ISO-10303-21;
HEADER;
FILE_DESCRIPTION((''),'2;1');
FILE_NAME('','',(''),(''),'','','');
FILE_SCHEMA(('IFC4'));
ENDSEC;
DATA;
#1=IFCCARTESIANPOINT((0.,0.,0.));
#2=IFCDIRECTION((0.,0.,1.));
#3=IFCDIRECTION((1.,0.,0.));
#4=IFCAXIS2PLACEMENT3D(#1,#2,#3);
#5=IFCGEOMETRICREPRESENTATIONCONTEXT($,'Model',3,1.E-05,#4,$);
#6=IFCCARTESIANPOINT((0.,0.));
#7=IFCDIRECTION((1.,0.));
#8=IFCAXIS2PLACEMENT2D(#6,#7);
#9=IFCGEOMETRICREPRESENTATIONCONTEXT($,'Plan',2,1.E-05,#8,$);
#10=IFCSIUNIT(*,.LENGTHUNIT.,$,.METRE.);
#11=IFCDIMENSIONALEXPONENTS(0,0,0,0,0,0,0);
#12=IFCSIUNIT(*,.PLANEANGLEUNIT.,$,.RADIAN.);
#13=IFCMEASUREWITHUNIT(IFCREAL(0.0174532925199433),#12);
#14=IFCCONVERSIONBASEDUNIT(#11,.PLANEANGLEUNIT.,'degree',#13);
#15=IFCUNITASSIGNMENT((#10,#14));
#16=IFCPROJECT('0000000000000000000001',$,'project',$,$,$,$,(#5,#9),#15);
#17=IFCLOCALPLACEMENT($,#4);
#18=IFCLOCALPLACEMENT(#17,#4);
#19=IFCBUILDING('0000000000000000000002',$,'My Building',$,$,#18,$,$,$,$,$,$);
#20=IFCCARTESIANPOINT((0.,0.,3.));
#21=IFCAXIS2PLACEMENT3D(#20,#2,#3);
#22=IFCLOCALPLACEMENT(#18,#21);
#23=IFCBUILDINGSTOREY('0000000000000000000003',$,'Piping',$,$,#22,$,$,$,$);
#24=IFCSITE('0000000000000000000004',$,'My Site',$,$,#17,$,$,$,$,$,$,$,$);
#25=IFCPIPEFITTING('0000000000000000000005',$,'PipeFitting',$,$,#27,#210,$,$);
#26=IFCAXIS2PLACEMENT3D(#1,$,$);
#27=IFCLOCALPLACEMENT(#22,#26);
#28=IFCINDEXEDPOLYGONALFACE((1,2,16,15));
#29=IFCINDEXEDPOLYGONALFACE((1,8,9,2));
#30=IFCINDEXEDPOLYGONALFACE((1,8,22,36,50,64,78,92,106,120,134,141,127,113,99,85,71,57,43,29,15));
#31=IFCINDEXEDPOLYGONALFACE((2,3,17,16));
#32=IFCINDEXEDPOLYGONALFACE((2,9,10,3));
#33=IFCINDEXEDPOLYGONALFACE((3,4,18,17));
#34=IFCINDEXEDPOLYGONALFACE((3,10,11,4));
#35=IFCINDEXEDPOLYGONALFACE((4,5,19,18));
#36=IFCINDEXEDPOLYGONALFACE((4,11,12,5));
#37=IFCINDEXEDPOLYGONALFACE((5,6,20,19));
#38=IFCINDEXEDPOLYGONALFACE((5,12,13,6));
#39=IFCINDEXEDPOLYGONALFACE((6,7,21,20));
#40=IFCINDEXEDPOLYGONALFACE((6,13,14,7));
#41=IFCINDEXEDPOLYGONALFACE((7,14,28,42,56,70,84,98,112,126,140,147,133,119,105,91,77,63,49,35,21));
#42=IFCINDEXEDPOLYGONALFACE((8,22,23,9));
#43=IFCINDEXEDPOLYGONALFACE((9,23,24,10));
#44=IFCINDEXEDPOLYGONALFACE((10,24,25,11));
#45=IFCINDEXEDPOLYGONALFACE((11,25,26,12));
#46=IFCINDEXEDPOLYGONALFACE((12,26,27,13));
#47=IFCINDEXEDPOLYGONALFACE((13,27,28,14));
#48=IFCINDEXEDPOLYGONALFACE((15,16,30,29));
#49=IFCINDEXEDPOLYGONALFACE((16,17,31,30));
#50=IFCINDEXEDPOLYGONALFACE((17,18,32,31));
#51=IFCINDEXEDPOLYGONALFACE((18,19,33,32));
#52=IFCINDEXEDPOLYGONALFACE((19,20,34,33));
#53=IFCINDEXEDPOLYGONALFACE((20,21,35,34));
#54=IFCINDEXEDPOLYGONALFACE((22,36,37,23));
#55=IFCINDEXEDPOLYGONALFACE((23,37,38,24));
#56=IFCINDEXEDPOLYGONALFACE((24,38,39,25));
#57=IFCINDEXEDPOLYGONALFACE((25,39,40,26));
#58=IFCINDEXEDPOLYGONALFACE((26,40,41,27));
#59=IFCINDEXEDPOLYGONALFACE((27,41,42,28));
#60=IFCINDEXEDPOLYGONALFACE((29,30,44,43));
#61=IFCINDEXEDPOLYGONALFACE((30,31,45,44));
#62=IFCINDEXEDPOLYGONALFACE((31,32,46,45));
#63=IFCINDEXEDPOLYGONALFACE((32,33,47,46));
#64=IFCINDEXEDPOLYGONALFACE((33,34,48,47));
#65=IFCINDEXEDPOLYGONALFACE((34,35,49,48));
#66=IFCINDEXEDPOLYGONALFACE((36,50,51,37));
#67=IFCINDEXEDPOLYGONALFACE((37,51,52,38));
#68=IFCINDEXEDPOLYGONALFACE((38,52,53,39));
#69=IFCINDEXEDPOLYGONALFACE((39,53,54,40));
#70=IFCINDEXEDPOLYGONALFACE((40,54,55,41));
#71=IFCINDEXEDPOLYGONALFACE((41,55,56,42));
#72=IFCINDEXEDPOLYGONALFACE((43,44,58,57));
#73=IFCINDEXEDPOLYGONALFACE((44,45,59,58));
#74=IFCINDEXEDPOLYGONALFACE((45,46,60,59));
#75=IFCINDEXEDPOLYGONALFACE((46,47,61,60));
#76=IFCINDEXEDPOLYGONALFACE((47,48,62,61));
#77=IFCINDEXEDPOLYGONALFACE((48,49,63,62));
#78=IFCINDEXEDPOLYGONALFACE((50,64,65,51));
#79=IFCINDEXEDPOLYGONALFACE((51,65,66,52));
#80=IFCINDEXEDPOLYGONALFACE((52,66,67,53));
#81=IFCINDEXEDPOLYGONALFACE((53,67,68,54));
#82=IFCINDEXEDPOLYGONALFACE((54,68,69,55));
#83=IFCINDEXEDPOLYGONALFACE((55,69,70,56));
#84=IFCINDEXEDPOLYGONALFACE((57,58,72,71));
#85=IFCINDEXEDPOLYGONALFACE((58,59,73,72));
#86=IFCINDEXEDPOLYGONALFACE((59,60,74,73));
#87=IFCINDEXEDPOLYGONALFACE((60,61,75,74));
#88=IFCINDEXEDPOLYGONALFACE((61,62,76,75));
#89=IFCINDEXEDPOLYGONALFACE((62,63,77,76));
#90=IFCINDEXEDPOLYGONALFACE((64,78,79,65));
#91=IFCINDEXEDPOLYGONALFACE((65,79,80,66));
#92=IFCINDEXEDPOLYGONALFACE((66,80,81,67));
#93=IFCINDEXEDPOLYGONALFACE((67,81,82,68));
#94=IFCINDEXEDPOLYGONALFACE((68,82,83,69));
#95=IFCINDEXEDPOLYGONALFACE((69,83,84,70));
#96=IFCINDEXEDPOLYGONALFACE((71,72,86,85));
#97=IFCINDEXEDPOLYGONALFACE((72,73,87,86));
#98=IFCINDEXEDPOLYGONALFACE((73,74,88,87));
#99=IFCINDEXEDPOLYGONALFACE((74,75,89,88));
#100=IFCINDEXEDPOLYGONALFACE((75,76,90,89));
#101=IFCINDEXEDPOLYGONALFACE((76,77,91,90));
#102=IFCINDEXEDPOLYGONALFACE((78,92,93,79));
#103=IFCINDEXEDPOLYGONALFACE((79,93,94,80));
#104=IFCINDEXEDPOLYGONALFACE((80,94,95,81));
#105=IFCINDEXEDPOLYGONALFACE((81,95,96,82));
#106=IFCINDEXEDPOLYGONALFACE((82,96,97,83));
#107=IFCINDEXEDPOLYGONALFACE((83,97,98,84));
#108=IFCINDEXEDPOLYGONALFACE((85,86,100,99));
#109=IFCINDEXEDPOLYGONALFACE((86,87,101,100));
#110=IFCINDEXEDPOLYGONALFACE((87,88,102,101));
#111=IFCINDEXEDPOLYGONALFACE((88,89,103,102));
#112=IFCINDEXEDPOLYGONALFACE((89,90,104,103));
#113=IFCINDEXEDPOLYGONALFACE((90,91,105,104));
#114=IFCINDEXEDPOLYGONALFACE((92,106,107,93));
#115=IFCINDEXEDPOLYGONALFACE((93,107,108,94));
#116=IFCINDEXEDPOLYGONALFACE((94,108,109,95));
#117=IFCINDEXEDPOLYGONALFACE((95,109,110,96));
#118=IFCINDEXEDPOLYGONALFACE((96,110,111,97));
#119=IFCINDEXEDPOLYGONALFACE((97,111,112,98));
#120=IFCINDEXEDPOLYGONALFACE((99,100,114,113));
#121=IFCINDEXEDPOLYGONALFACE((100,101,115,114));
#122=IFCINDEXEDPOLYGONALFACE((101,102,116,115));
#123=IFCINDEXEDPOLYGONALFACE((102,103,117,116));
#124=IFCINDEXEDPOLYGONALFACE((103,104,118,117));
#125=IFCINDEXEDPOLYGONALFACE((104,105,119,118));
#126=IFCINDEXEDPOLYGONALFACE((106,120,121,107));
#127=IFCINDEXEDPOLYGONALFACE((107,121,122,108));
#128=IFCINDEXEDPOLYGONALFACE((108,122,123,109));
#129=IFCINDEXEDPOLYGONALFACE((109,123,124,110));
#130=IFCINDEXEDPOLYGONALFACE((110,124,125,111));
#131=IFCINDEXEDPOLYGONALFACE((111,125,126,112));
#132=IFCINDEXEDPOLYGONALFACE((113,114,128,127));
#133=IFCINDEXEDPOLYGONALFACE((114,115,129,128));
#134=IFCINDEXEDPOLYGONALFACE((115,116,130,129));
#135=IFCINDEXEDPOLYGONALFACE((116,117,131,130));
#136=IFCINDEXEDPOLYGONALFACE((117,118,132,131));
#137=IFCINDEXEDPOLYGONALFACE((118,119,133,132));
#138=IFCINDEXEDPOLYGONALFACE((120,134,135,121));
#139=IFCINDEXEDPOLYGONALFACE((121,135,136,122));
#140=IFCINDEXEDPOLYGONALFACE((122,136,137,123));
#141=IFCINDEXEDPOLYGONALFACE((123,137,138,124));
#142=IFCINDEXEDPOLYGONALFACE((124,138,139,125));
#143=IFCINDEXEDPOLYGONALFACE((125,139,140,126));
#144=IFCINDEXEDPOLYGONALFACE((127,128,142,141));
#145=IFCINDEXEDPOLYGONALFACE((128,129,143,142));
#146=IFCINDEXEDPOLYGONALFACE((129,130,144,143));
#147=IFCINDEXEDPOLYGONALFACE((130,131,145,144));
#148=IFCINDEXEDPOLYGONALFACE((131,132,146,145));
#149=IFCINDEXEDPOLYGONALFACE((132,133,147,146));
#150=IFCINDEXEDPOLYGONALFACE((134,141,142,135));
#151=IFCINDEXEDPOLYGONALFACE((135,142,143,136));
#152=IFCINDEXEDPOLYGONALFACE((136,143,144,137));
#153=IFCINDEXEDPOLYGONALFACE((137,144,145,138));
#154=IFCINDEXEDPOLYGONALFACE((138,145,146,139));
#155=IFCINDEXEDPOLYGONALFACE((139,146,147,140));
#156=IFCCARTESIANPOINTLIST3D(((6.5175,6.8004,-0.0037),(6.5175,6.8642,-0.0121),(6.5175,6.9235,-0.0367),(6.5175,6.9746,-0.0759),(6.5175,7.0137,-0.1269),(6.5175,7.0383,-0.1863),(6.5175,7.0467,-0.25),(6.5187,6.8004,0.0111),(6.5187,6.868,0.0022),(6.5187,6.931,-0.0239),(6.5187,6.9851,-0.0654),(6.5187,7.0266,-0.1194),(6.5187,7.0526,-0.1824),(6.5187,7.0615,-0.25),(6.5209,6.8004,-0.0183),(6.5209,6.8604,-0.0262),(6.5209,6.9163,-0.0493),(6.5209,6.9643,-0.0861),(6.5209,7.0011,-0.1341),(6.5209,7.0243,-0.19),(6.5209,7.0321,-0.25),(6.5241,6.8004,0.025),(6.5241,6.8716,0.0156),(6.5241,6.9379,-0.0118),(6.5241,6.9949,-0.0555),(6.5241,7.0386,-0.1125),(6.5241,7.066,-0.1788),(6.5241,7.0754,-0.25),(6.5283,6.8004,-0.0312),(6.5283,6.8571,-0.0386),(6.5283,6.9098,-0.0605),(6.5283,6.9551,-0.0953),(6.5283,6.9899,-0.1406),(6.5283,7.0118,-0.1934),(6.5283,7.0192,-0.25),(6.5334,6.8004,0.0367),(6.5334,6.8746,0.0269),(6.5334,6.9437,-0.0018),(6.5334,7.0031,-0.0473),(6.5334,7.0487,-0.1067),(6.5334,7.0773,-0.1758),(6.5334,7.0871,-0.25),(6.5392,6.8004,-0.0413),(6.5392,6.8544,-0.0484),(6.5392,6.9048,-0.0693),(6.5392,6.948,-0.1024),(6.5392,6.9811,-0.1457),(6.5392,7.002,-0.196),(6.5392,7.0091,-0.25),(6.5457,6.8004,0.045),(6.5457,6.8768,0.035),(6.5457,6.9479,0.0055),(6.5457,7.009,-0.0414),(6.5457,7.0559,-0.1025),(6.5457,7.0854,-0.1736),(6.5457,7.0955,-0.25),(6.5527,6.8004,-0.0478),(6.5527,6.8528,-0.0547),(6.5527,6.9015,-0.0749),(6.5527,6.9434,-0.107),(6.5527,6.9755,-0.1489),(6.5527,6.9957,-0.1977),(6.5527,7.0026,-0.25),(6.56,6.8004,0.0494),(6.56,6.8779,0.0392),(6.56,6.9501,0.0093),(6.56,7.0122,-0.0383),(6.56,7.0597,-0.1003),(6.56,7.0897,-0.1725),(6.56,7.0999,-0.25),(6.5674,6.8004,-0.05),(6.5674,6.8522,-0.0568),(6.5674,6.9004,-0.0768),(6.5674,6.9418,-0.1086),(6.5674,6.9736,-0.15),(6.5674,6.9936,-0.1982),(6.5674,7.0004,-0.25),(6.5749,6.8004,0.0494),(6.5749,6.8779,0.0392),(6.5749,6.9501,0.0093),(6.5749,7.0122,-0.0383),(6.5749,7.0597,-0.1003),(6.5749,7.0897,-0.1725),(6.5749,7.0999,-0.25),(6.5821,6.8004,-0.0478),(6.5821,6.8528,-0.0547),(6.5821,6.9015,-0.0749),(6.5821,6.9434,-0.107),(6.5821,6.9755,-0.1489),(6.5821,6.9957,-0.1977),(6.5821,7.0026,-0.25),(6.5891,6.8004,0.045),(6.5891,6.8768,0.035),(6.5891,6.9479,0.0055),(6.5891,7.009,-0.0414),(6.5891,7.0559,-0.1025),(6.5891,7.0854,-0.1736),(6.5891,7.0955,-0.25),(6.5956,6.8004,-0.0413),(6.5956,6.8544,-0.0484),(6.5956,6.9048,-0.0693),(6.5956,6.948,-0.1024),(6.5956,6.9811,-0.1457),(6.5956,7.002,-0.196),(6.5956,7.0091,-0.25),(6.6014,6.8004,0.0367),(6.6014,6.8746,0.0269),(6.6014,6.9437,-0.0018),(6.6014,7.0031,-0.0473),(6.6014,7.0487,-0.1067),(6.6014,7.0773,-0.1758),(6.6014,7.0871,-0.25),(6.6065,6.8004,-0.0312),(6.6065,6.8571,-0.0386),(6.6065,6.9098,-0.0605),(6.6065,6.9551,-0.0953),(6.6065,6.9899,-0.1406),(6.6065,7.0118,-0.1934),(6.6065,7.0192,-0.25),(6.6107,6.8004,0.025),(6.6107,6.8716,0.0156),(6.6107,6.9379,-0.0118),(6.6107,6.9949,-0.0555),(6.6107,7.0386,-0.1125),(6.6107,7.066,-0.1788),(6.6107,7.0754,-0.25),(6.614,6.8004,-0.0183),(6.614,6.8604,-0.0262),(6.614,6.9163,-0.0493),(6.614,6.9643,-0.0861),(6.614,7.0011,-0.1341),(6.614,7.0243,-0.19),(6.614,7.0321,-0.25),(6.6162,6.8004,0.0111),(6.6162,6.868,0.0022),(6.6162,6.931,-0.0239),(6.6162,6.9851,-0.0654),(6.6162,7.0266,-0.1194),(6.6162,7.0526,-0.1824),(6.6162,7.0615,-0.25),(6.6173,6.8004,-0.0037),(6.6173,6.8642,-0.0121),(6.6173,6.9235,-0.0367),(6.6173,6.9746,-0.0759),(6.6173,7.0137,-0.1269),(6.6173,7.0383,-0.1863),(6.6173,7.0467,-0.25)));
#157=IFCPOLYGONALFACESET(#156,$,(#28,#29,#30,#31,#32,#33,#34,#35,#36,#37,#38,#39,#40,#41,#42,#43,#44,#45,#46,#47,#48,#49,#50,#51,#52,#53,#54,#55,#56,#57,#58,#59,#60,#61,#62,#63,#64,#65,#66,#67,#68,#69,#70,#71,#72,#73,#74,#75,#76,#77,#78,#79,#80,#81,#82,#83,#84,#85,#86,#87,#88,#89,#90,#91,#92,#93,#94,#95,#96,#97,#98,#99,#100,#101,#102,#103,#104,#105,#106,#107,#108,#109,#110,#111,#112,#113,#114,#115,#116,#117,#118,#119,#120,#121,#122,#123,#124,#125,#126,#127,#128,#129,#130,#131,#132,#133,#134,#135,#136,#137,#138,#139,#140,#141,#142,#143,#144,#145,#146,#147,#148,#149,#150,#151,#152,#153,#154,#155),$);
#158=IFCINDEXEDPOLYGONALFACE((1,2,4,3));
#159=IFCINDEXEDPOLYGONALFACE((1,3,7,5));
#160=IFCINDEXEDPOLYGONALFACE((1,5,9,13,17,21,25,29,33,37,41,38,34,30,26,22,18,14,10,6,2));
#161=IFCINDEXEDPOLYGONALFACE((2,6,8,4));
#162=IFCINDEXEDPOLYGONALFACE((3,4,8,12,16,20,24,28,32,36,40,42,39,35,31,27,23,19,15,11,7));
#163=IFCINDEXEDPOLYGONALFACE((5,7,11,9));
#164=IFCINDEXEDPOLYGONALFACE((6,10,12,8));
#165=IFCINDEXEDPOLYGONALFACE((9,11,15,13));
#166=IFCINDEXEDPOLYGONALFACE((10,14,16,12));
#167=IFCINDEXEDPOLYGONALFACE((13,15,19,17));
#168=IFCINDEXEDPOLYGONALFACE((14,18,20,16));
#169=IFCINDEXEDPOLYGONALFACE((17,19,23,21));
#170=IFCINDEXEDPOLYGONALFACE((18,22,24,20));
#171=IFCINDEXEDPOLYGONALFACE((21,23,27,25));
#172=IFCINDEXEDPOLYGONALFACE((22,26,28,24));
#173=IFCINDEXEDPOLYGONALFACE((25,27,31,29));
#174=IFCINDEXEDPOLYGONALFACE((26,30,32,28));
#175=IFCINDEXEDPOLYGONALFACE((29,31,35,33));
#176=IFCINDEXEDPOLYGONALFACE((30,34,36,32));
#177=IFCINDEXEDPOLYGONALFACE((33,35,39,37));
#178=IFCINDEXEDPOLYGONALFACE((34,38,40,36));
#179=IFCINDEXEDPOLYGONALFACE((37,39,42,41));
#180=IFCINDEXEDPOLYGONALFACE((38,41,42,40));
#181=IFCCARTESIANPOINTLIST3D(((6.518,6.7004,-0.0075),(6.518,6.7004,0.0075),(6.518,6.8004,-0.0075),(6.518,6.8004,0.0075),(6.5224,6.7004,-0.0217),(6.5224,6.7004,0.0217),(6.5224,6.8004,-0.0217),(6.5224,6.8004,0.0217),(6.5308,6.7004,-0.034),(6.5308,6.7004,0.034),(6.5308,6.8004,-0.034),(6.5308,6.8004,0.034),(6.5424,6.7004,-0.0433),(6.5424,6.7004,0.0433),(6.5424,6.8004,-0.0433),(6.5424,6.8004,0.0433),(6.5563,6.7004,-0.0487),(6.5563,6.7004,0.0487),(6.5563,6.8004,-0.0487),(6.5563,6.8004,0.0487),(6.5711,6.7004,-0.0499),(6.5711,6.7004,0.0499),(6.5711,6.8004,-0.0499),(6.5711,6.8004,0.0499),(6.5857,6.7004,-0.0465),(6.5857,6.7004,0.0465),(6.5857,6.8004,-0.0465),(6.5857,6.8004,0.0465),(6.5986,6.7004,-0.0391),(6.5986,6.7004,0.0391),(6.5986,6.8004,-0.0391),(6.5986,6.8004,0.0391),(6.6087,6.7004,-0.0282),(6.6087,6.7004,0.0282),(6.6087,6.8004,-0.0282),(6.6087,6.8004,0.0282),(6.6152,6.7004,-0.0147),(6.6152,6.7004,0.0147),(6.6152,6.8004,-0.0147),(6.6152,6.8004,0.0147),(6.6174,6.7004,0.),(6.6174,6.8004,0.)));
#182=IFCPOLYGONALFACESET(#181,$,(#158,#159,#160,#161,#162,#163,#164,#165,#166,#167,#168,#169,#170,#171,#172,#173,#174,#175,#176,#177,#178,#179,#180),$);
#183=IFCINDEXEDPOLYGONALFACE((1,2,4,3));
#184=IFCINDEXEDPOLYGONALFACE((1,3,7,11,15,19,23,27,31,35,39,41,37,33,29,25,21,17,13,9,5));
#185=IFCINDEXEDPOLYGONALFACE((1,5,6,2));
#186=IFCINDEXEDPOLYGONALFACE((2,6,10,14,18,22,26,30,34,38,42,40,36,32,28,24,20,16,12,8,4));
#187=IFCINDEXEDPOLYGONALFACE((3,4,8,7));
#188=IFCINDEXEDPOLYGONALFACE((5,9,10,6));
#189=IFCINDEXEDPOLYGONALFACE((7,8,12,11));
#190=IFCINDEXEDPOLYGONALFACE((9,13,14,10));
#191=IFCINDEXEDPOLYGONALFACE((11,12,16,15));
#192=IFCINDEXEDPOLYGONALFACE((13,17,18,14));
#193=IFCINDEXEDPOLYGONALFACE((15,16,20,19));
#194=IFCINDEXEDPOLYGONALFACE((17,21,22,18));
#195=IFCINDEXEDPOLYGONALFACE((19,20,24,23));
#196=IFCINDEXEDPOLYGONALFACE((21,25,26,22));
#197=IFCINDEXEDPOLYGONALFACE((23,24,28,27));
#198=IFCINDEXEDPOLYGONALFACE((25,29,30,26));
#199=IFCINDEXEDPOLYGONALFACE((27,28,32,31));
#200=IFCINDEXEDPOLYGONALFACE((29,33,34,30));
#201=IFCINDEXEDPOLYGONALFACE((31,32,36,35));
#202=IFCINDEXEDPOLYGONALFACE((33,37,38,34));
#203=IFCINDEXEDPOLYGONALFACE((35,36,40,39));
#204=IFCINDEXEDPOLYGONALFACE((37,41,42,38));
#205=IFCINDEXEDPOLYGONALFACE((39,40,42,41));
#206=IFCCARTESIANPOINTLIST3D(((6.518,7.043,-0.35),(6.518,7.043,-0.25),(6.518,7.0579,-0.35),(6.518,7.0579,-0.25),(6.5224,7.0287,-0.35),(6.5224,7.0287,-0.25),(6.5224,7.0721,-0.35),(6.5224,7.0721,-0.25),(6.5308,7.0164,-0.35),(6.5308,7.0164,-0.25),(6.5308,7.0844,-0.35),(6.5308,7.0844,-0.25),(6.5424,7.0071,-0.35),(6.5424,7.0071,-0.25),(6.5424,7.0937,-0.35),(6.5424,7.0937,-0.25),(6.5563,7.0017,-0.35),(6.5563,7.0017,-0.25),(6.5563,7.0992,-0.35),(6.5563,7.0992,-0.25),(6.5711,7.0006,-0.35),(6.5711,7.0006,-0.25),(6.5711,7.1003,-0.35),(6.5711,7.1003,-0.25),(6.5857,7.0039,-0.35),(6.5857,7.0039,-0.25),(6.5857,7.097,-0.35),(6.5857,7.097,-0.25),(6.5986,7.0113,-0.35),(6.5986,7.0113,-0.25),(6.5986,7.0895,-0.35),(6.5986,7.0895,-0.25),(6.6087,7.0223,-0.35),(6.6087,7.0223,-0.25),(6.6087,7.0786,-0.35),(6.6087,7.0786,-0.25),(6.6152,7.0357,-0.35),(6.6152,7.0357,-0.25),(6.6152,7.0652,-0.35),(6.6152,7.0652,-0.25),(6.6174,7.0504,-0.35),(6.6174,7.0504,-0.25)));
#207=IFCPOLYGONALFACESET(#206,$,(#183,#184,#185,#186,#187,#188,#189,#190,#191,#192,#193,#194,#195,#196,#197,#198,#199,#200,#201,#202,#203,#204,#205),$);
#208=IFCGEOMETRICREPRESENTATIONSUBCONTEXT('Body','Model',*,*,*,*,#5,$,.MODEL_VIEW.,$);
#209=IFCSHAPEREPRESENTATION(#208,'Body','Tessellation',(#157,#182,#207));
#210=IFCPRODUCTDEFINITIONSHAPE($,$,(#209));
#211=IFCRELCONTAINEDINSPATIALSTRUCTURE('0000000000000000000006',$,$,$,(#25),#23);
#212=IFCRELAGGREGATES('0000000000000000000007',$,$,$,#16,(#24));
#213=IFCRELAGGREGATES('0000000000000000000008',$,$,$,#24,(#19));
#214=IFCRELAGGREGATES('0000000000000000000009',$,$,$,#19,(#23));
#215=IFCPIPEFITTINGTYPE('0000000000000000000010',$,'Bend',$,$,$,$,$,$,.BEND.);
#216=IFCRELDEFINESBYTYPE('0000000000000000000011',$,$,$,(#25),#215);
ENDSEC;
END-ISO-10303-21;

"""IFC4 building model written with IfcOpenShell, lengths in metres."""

from ifc_helpers import new_model, entity, si_unit, converted_unit, frame, origin_with_axes, origin_2d_with_axis, place, context, subcontext, project, spatial, circle, extrude, source, transform, mapped, type_object, type_shapes, element, save


model = new_model("IFC4")

# Units and contexts
model_context = context("Model", 3, precision=1e-05, world=origin_with_axes())
plan_context = context("Plan", 2, precision=1e-05, world=origin_2d_with_axis())
body_context = subcontext(model_context, "Body", "Model", "MODEL_VIEW")
ifc_project = project(units=[si_unit("LENGTHUNIT", "METRE"), converted_unit("PLANEANGLEUNIT", "degree", entity("IfcReal", 0.0174532925199433), si_unit("PLANEANGLEUNIT", "RADIAN"), dimensions=[0, 0, 0, 0, 0, 0, 0])], contexts=[model_context, plan_context])

# Site, building, storey
site_placement = place(None, origin_with_axes())
site = spatial("IfcSite", under=ifc_project, at=site_placement, Name="My Site")
building_placement = place(site_placement, origin_with_axes())
building = spatial("IfcBuilding", under=site, at=building_placement, Name="My Building")
storey_placement = place(building_placement, frame((0.0, 0.0, 3.0), z_axis=(0.0, 0.0, 1.0), x_axis=(1.0, 0.0, 0.0)))
storey = spatial("IfcBuildingStorey", under=building, at=storey_placement, Name="Piping")

# Pipe fitting
pipe_fitting_type = type_object("IfcPipeFittingType", Name="Bend", PredefinedType="BEND")
shared_shape = source(origin_with_axes(), body_context, "Body", "SolidModel", [
    entity("IfcSweptDiskSolid", entity("IfcIndexedPolyCurve", entity("IfcCartesianPointList3D", [[0.0, 0.0, -0.1], [0.0, -0.0732, -0.2768], [0.0, -0.25, -0.35]]), [entity("IfcArcIndex", [1, 2, 3])]), 0.05),
    extrude(circle(Radius=0.05), origin_with_axes(), (0.0, 0.0, -1.0), 0.1),
    extrude(circle(Radius=0.05), frame((0.0, -0.25, -0.35), z_axis=(0.0, -1.0, 0.0), x_axis=(1.0, 0.0, 0.0)), (0.0, 0.0, 1.0), 0.1),
])
type_shapes(pipe_fitting_type, [shared_shape])
for number, where, z_axis, x_axis, name in (
    (1, (6.5674, 6.7004, 0.0), (0.0, -1.0, 0.0), (1.0, 0.0, 0.0), "PipeFitting"),
):
    element("IfcPipeFitting", number, at=place(storey_placement, frame(where, z_axis=z_axis, x_axis=x_axis)), inside=storey, type_object=pipe_fitting_type, Name=name, context=body_context, shape_type="MappedRepresentation", body=[
        mapped(shared_shape, transform((0.0, 0.0, 0.0), x_axis=(1.0, 0.0, 0.0), y_axis=(0.0, 1.0, 0.0), z_axis=(0.0, 0.0, 1.0), scale=1.0)),
    ])

save(model, "model.ifc")
